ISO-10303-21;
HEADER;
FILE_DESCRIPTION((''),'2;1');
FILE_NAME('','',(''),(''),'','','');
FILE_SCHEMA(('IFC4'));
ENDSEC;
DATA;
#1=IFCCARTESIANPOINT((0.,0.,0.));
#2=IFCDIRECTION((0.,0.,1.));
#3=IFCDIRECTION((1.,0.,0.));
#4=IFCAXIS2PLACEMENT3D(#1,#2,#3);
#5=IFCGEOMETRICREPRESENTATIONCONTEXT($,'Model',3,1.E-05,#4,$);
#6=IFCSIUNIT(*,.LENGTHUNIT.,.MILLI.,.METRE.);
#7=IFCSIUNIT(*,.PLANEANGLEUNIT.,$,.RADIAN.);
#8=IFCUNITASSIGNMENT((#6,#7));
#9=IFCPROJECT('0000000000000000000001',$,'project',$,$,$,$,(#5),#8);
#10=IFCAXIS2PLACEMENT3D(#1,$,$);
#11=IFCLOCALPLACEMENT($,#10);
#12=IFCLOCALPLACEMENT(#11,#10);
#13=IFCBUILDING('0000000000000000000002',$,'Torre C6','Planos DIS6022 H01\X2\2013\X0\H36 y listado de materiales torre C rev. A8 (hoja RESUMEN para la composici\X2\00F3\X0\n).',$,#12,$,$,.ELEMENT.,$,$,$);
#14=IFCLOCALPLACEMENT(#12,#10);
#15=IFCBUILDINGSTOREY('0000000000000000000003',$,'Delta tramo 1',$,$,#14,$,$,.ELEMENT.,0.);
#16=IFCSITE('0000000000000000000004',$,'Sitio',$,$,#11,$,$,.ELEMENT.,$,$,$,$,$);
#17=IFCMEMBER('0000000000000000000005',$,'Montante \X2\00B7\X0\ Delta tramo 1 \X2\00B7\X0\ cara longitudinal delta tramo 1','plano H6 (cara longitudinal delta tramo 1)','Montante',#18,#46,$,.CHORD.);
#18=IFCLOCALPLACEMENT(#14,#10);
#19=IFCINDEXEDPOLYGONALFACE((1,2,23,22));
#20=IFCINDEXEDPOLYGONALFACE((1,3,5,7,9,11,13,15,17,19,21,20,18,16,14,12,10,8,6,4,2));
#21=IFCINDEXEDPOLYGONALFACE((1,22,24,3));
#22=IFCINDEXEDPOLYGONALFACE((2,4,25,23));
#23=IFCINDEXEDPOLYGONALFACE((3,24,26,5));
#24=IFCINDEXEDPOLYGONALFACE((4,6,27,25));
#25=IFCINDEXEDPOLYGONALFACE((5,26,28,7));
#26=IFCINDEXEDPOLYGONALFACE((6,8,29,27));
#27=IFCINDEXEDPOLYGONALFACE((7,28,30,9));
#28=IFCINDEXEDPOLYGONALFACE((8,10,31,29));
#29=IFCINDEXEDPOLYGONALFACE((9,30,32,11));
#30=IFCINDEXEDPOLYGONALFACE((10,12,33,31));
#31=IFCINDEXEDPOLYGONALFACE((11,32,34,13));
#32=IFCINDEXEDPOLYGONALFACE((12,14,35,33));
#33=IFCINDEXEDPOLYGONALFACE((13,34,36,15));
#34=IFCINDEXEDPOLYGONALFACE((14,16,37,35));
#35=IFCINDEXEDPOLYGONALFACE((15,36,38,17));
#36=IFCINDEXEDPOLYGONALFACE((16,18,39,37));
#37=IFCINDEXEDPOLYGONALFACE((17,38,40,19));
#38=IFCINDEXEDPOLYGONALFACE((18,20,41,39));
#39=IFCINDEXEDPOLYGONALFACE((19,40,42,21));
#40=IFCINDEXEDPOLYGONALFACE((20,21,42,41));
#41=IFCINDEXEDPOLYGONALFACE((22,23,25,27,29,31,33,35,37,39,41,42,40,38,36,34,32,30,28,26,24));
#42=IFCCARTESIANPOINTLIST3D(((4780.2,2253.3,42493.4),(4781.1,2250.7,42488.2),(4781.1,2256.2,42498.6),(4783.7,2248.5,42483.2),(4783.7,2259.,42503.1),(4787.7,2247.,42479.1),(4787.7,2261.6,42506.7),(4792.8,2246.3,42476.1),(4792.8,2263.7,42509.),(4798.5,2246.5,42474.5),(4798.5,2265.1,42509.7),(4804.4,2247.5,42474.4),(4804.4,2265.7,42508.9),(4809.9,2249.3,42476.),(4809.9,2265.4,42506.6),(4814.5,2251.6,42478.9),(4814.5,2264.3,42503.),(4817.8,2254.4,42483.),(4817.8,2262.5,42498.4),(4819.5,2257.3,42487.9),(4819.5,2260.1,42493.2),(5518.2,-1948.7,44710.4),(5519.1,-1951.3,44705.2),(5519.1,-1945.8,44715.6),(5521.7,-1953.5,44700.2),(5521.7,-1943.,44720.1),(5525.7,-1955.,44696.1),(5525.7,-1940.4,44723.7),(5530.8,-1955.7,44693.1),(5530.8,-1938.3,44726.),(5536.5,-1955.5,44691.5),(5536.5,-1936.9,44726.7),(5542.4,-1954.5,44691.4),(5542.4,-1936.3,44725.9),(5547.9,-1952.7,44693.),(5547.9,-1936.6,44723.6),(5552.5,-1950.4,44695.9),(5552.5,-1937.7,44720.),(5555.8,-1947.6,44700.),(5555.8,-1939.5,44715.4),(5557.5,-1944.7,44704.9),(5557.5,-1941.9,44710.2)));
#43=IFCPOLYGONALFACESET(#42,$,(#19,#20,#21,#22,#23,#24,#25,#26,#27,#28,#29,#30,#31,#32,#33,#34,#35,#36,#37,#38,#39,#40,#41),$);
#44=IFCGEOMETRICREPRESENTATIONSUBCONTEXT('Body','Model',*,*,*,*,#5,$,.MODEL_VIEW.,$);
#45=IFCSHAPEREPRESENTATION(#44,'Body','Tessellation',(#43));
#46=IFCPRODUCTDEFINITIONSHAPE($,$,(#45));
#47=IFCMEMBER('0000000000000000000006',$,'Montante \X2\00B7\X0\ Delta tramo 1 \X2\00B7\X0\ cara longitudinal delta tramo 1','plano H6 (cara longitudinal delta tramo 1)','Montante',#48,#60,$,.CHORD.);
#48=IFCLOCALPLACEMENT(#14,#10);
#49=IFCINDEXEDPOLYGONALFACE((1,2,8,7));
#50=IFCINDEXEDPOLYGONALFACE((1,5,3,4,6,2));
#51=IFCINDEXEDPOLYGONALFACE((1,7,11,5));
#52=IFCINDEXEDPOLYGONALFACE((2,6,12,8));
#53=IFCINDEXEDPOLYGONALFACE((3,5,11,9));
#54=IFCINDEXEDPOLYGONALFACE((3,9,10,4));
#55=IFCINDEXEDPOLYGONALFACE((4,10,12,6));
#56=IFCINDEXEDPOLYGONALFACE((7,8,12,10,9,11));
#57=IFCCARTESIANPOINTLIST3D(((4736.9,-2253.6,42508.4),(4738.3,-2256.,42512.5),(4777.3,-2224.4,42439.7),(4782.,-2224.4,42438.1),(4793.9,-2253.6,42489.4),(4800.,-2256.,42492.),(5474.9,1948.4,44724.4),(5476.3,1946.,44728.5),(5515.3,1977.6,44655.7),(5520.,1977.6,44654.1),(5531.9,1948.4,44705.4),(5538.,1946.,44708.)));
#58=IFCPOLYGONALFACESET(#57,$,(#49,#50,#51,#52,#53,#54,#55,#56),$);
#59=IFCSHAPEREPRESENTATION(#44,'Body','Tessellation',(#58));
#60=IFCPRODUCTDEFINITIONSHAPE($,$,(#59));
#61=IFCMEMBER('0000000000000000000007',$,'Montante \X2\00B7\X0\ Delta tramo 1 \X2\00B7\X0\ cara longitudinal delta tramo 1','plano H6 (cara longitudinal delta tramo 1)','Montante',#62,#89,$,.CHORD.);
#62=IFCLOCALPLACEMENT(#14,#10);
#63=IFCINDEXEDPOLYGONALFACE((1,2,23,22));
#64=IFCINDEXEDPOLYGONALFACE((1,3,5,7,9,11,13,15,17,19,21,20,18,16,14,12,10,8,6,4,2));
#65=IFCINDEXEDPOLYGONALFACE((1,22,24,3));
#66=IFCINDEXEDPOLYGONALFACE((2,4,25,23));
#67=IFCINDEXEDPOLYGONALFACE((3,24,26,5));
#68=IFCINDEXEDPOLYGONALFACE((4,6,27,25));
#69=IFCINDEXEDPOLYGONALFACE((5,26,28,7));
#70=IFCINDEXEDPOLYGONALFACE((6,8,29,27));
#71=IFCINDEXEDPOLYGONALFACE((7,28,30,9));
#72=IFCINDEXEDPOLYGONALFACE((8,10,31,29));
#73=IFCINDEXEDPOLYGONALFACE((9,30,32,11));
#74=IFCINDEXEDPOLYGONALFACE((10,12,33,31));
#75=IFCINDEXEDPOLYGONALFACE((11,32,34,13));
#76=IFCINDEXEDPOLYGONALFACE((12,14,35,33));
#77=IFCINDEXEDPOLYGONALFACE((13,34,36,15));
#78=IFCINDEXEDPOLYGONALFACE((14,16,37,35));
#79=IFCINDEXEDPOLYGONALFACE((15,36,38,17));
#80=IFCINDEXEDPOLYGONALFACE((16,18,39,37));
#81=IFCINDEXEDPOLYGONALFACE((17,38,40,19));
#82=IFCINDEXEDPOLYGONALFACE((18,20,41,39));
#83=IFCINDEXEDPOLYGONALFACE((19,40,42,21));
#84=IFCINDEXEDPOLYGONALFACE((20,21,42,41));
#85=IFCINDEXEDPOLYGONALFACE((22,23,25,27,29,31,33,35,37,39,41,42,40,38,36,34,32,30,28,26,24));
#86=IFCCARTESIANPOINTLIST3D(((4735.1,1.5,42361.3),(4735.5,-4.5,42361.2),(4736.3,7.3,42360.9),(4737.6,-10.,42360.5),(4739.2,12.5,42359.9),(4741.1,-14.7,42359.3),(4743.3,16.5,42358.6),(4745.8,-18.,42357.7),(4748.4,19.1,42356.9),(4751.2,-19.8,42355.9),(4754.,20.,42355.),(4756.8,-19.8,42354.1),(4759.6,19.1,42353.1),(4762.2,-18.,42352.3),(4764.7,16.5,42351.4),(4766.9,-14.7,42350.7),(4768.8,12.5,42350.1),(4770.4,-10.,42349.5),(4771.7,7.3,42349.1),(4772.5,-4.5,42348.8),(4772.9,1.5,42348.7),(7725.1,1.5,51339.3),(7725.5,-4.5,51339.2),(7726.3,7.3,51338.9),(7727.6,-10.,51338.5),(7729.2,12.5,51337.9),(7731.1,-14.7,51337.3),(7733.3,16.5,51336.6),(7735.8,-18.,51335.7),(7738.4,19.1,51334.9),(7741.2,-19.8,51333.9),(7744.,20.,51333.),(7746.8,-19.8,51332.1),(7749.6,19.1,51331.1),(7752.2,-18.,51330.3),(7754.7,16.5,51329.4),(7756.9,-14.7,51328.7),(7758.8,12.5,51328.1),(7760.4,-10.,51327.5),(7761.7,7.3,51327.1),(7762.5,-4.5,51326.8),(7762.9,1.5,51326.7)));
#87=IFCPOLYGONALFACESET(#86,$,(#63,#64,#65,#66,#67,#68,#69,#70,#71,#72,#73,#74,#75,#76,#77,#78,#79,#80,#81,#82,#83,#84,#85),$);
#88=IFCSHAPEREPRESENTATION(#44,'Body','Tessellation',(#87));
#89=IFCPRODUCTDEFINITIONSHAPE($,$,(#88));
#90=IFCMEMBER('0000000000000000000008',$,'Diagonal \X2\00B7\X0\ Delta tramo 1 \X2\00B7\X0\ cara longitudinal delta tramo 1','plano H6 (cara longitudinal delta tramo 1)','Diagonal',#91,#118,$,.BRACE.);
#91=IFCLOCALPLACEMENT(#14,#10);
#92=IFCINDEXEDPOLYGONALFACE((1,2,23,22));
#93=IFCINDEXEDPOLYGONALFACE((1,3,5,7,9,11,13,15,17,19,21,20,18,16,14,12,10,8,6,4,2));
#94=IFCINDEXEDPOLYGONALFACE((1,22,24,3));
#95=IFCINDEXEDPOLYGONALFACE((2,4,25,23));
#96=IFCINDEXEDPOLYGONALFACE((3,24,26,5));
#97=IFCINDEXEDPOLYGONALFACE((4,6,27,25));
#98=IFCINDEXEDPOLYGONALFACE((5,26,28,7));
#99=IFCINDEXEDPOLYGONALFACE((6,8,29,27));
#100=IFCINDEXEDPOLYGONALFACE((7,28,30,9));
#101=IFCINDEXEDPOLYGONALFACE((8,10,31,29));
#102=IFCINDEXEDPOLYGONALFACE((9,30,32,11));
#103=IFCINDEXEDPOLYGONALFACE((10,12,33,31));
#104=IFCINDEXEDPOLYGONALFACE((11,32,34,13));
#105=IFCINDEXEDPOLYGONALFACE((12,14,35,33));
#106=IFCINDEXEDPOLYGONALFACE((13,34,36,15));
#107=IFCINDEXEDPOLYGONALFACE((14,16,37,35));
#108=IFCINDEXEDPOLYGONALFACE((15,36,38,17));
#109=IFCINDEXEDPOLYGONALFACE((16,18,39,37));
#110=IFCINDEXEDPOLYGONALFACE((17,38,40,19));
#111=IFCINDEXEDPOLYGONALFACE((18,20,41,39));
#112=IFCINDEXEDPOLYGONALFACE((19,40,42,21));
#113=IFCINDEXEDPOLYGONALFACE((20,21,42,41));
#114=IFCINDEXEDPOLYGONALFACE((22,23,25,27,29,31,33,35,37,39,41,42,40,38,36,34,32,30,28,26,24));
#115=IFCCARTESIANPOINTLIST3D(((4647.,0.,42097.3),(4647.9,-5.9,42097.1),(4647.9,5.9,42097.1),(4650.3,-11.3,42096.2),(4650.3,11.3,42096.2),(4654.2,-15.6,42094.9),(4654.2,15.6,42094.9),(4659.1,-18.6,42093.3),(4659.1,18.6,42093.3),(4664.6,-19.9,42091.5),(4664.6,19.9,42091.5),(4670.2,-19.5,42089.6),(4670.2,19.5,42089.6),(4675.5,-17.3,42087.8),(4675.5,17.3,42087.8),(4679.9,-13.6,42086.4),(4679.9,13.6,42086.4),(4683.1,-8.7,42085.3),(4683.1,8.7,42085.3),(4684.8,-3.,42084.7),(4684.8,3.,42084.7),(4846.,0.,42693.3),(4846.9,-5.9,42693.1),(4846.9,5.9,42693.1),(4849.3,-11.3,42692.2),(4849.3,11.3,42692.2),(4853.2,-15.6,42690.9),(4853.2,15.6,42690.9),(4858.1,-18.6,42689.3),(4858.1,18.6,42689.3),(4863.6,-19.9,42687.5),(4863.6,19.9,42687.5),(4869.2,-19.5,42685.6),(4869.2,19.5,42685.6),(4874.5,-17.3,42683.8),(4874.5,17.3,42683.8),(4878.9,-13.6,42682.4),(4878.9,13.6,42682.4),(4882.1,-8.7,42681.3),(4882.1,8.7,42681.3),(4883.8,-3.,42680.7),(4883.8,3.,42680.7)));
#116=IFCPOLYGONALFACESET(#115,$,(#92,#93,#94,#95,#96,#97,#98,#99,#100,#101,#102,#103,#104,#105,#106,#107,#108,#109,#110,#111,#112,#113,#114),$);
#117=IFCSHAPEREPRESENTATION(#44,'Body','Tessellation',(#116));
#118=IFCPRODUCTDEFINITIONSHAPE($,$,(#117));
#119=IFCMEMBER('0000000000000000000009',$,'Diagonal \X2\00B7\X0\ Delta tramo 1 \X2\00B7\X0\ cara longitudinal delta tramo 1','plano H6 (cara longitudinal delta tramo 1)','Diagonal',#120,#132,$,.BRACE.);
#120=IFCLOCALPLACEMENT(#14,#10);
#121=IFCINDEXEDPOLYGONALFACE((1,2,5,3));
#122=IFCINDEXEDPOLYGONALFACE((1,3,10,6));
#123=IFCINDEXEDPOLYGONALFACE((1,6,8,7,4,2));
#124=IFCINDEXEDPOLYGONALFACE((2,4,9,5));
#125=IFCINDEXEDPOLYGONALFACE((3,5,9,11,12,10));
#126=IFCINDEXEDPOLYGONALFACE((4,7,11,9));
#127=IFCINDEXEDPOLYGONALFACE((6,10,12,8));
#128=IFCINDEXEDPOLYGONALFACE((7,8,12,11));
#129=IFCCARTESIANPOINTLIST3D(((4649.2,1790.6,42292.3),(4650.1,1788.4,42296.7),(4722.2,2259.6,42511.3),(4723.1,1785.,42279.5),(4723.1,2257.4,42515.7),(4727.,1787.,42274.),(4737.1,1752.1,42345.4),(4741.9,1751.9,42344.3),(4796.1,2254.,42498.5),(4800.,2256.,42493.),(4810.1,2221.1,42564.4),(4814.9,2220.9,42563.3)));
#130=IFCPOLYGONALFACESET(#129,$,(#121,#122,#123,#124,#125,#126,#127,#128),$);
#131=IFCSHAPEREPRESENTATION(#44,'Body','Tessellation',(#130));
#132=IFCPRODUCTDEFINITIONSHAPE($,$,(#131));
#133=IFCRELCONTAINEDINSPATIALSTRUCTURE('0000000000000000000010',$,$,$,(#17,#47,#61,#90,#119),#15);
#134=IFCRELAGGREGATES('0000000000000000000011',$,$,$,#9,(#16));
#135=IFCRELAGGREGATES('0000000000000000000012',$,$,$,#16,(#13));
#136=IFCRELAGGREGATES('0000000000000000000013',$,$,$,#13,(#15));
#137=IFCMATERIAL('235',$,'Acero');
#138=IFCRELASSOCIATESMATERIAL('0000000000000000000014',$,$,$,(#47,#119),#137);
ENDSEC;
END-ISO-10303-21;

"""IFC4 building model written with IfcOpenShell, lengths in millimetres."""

from ifc_helpers import new_model, si_unit, frame, frame_2d, origin, origin_with_axes, place, context, subcontext, project, spatial, circle, l_section, extrude, material, element, save


model = new_model("IFC4")

# Units and contexts
model_context = context("Model", 3, precision=1e-05, world=origin_with_axes())
body_context = subcontext(model_context, "Body", "Model", "MODEL_VIEW")
ifc_project = project(units=[si_unit("LENGTHUNIT", "METRE", prefix="MILLI"), si_unit("PLANEANGLEUNIT", "RADIAN")], contexts=[model_context])

# Site, building, storey
site_placement = place(None, origin())
site = spatial("IfcSite", under=ifc_project, at=site_placement, Name="Sitio", CompositionType="ELEMENT")
building_placement = place(site_placement, origin())
building = spatial("IfcBuilding", under=site, at=building_placement, Name="Torre C6", Description="Planos DIS6022 H01–H36 y listado de materiales torre C rev. A8 (hoja RESUMEN para la composición).", CompositionType="ELEMENT")
storey_placement = place(building_placement, origin())
storey = spatial("IfcBuildingStorey", under=building, at=storey_placement, Name="Delta tramo 1", CompositionType="ELEMENT", Elevation=0.0)

# Members
member_1_placement = place(storey_placement, frame((4800.0, 2256.0, 42492.0), z_axis=(0.153495, -0.873966, 0.46111), x_axis=(-0.988149, -0.135759, 0.071627)))
element("IfcMember", 1, at=member_1_placement, inside=storey, Name="Montante · Delta tramo 1 · cara longitudinal delta tramo 1", Description="plano H6 (cara longitudinal delta tramo 1)", ObjectType="Montante", PredefinedType="CHORD", context=body_context, shape_type="SweptSolid", body=[
    extrude(circle(Radius=20.0), None, (0.0, 0.0, 1.0), 4808.0),
])
ifc_material_1 = material(Name="235", Category="Acero")
member_2_placement = place(storey_placement, frame((4800.0, -2256.0, 42492.0), z_axis=(0.15351, 0.87405, 0.460946), x_axis=(-0.276174, 0.485836, -0.829272)))
element("IfcMember", 2, at=member_2_placement, inside=storey, material=ifc_material_1, Name="Montante · Delta tramo 1 · cara longitudinal delta tramo 1", Description="plano H6 (cara longitudinal delta tramo 1)", ObjectType="Montante", PredefinedType="CHORD", context=body_context, shape_type="SweptSolid", body=[
    extrude(l_section(Depth=65.0, Width=65.0, Thickness=5.0, at=frame_2d((32.5, 32.5))), None, (0.0, 0.0, 1.0), 4807.5),
])
member_3_placement = place(storey_placement, frame((4754.0, 0.0, 42355.0), z_axis=(0.315974, 0.0, 0.948768), x_axis=(0.0, 1.0, 0.0)))
element("IfcMember", 3, at=member_3_placement, inside=storey, Name="Montante · Delta tramo 1 · cara longitudinal delta tramo 1", Description="plano H6 (cara longitudinal delta tramo 1)", ObjectType="Montante", PredefinedType="CHORD", context=body_context, shape_type="SweptSolid", body=[
    extrude(circle(Radius=20.0), None, (0.0, 0.0, 1.0), 9462.8),
])
member_4_placement = place(storey_placement, frame((4666.0, 0.0, 42091.0), z_axis=(0.316705, 0.0, 0.948524), x_axis=(-0.948524, 0.0, 0.316705)))
element("IfcMember", 4, at=member_4_placement, inside=storey, Name="Diagonal · Delta tramo 1 · cara longitudinal delta tramo 1", Description="plano H6 (cara longitudinal delta tramo 1)", ObjectType="Diagonal", PredefinedType="BRACE", context=body_context, shape_type="SweptSolid", body=[
    extrude(circle(Radius=20.0), None, (0.0, 0.0, 1.0), 628.3),
])
member_5_placement = place(storey_placement, frame((4727.0, 1787.0, 42274.0), z_axis=(0.13965, 0.897206, 0.418951), x_axis=(-0.972489, 0.044604, 0.22864)))
element("IfcMember", 5, at=member_5_placement, inside=storey, material=ifc_material_1, Name="Diagonal · Delta tramo 1 · cara longitudinal delta tramo 1", Description="plano H6 (cara longitudinal delta tramo 1)", ObjectType="Diagonal", PredefinedType="BRACE", context=body_context, shape_type="SweptSolid", body=[
    extrude(l_section(Depth=80.0, Width=80.0, Thickness=5.0, at=frame_2d((40.0, 40.0))), None, (0.0, 0.0, 1.0), 522.7),
])

save(model, "model.ifc")
